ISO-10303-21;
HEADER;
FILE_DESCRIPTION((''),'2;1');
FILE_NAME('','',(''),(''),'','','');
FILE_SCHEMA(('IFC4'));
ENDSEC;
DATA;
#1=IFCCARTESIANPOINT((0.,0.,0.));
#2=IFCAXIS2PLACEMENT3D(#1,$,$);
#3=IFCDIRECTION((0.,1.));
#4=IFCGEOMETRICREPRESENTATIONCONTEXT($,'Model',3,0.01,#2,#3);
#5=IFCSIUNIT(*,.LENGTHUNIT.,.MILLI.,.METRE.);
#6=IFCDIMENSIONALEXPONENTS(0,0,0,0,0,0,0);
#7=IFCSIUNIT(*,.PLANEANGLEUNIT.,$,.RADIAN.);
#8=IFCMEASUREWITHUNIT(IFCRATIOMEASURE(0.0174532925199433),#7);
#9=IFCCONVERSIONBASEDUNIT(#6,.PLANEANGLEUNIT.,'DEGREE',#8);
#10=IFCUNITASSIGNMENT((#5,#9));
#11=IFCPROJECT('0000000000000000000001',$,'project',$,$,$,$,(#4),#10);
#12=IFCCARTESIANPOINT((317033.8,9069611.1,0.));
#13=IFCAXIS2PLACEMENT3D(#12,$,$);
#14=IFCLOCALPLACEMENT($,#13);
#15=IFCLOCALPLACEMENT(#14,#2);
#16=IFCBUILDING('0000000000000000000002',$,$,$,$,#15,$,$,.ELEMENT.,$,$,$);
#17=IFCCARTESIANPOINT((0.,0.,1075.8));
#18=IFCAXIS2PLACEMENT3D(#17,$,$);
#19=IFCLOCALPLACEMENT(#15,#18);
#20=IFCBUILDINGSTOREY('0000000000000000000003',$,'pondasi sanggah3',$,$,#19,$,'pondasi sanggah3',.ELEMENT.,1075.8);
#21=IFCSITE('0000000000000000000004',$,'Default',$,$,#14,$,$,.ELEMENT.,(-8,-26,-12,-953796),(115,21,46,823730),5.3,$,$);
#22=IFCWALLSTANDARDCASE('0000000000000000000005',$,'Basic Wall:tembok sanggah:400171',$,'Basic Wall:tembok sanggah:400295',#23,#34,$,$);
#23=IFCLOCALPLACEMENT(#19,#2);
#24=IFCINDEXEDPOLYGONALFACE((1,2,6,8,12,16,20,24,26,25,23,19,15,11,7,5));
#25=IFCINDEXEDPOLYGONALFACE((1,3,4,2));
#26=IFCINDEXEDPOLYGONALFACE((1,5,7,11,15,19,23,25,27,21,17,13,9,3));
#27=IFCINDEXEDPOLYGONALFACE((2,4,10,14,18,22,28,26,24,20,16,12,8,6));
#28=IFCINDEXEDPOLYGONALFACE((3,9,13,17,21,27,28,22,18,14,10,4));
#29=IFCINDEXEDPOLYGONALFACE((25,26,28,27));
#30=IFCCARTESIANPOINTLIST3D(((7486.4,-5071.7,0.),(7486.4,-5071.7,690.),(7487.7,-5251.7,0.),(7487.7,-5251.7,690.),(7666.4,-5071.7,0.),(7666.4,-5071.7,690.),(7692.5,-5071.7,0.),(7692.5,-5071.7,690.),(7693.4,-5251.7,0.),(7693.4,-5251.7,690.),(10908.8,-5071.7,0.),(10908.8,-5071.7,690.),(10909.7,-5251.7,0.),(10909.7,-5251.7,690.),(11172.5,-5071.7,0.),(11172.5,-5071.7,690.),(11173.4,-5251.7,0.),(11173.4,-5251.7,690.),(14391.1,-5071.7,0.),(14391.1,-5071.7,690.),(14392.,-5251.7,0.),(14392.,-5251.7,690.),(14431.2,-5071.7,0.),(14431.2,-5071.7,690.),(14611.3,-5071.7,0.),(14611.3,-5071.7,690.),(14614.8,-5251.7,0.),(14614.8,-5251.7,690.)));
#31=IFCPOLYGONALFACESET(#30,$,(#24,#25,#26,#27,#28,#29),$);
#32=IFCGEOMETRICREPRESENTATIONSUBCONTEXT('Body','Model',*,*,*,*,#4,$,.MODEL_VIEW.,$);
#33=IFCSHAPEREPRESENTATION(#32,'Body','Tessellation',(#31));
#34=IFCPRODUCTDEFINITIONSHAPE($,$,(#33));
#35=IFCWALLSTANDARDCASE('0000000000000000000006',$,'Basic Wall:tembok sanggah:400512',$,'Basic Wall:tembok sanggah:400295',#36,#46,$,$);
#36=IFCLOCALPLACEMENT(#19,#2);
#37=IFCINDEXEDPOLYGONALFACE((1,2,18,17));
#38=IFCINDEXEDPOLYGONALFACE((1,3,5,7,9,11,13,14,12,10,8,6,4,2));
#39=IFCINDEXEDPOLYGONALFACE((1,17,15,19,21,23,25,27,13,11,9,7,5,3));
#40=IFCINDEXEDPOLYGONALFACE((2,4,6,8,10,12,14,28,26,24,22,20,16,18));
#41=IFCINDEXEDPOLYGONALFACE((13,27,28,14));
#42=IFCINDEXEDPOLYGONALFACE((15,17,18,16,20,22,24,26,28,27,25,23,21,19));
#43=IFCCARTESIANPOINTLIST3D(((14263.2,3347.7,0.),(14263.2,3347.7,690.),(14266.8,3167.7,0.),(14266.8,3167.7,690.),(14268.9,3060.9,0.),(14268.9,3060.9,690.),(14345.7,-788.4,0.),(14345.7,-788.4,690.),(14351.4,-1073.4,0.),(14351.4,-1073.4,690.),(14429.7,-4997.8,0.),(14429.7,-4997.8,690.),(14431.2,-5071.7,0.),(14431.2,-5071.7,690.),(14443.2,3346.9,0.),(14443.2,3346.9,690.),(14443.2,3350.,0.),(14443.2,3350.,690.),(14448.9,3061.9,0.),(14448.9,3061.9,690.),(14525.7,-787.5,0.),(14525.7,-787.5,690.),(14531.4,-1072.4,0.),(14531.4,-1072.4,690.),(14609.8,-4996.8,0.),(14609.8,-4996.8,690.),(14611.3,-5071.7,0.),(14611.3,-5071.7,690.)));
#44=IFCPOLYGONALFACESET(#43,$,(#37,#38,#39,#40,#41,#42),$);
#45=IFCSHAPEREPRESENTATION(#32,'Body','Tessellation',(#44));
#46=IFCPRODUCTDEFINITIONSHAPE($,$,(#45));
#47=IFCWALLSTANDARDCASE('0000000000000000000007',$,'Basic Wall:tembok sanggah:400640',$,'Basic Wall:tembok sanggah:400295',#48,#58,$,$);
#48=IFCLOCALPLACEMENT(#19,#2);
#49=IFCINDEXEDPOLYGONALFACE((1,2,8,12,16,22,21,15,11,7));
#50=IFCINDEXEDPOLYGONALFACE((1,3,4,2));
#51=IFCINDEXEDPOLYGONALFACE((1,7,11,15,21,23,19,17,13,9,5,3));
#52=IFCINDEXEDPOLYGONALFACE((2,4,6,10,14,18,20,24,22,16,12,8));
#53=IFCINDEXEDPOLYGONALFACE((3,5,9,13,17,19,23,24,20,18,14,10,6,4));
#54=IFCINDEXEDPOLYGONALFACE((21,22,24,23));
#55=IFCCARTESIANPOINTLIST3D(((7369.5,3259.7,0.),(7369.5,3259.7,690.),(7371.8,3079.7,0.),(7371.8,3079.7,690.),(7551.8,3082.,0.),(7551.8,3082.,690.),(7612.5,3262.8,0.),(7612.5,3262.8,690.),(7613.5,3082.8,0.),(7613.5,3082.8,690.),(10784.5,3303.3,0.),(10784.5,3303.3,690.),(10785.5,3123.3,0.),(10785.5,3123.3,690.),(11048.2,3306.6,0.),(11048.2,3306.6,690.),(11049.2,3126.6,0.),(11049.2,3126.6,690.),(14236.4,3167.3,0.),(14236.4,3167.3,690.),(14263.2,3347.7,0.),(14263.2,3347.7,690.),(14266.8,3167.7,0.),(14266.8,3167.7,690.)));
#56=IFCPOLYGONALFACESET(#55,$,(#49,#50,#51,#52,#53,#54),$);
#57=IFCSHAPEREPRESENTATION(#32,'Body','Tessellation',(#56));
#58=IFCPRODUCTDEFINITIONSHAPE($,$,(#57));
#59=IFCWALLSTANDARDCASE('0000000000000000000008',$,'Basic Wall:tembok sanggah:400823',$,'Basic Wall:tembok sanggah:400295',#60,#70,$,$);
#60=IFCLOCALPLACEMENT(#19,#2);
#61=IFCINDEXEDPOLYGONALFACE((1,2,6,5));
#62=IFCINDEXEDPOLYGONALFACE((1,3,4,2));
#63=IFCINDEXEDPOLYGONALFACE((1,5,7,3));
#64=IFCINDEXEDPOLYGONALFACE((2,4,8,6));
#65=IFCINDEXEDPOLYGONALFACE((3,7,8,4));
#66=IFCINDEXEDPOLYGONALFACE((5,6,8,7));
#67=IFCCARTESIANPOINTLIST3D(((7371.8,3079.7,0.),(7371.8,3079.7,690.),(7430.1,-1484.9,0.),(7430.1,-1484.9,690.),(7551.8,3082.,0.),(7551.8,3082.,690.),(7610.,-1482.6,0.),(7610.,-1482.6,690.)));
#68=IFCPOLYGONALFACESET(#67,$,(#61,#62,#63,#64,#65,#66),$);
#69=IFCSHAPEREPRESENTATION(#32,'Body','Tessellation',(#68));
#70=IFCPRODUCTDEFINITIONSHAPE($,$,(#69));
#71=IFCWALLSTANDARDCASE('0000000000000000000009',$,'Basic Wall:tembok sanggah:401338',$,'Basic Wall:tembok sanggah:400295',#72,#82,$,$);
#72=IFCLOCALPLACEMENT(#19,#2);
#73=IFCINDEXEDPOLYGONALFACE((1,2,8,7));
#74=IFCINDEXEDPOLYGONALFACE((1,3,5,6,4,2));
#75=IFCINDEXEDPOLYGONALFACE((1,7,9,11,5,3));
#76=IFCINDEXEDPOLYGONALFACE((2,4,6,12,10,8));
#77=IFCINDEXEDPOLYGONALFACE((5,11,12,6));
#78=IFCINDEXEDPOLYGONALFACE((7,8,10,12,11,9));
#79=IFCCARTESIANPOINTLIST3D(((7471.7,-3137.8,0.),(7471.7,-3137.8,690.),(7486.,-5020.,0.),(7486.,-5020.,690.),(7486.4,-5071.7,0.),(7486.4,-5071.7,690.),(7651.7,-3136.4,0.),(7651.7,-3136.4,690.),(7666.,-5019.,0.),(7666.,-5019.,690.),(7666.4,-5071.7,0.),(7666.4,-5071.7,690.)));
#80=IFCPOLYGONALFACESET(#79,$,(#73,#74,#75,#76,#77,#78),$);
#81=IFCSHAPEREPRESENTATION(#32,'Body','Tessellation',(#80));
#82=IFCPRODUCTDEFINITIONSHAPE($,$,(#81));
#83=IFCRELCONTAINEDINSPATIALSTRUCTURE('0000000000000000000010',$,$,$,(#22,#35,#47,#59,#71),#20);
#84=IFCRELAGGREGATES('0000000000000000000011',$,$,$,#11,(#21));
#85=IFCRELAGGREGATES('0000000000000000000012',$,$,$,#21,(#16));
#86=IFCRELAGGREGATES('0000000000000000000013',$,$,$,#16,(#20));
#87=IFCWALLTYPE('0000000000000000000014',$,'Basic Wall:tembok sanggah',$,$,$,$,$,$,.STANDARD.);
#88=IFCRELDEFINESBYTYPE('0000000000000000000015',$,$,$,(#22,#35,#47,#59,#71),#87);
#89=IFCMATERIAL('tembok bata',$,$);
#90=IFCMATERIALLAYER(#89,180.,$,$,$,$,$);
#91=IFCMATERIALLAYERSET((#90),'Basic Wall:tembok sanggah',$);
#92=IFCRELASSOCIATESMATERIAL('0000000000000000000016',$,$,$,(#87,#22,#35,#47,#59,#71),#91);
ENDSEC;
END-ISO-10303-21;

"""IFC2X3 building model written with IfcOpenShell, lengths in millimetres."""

from ifc_helpers import new_model, entity, si_unit, converted_unit, direction, frame, frame_2d, origin, place, context, subcontext, project, spatial, polyline, rectangle, outline, extrude, material, layer, layer_set, layer_usage, type_object, element, save


model = new_model("IFC2X3")

# Units and contexts
model_context = context("Model", 3, precision=0.01, world=origin(), true_north=direction((0.0, 1.0)))
body_context = subcontext(model_context, "Body", "Model", "MODEL_VIEW")
ifc_project = project(units=[si_unit("LENGTHUNIT", "METRE", prefix="MILLI"), converted_unit("PLANEANGLEUNIT", "DEGREE", entity("IfcRatioMeasure", 0.0174532925199433), si_unit("PLANEANGLEUNIT", "RADIAN"), dimensions=[0, 0, 0, 0, 0, 0, 0])], contexts=[model_context])

# Site, building, storey
site_placement = place(None, frame((317033.8, 9069611.1, 0.0)))
site = spatial("IfcSite", under=ifc_project, at=site_placement, Name="Default", CompositionType="ELEMENT", RefLatitude=(-8, -26, -12, -953796), RefLongitude=(115, 21, 46, 823730), RefElevation=5.3)
building_placement = place(site_placement, origin())
building = spatial("IfcBuilding", under=site, at=building_placement, CompositionType="ELEMENT")
storey_placement = place(building_placement, frame((0.0, 0.0, 1075.8)))
storey = spatial("IfcBuildingStorey", under=building, at=storey_placement, Name="pondasi sanggah3", LongName="pondasi sanggah3", CompositionType="ELEMENT", Elevation=1075.8)

# Walls
ifc_material_1 = material(Name="tembok bata")
ifc_layer_1 = layer(ifc_material_1, 180.0)
ifc_layer_set_1 = layer_set([ifc_layer_1], Name="Basic Wall:tembok sanggah")
ifc_layer_usage_1 = layer_usage(ifc_layer_set_1, "AXIS2", "NEGATIVE", 90.0)
wall_type = type_object("IfcWallType", Name="Basic Wall:tembok sanggah", PredefinedType="STANDARD", material=ifc_layer_set_1)
wall_1_placement = place(storey_placement, frame((7486.4, -5161.7, 0.0)))
element("IfcWallStandardCase", 1, at=wall_1_placement, inside=storey, type_object=wall_type, material=ifc_layer_usage_1, Name="Basic Wall:tembok sanggah:400171", ObjectType="Basic Wall:tembok sanggah:400295", context=body_context, shape_type="SweptSolid", body=[
    extrude(outline(polyline([(7128.5, -90.0), (7124.9, 90.0), (6944.9, 90.0), (6904.7, 90.0), (3686.1, 90.0), (3422.4, 90.0), (206.1, 90.0), (180.0, 90.0), (0.0, 90.0), (1.4, -90.0), (207.1, -90.0), (3423.4, -90.0), (3687.1, -90.0), (6905.7, -90.0), (7128.5, -90.0)])), origin(), (0.0, 0.0, 1.0), 690.0),
])
ifc_layer_usage_2 = layer_usage(ifc_layer_set_1, "AXIS2", "NEGATIVE", 90.0)
wall_2_placement = place(storey_placement, frame((14521.3, -5073.5, 0.0), z_axis=(0.0, 0.0, 1.0), x_axis=(-0.019956, 0.999801, 0.0)))
element("IfcWallStandardCase", 2, at=wall_2_placement, inside=storey, type_object=wall_type, material=ifc_layer_usage_2, Name="Basic Wall:tembok sanggah:400512", ObjectType="Basic Wall:tembok sanggah:400295", context=body_context, shape_type="SweptSolid", body=[
    extrude(outline(polyline([(8423.4, -90.0), (8424.7, 90.0), (8244.6, 90.0), (8137.9, 90.0), (4287.7, 90.0), (4002.7, 90.0), (77.6, 90.0), (3.6, 90.0), (0.0, -90.0), (74.9, -90.0), (4000.1, -90.0), (4285.1, -90.0), (8135.2, -90.0), (8420.3, -90.0), (8423.4, -90.0)])), origin(), (0.0, 0.0, 1.0), 690.0),
])
ifc_layer_usage_3 = layer_usage(ifc_layer_set_1, "AXIS2", "NEGATIVE", 90.0)
wall_3_placement = place(storey_placement, frame((14265.6, 3257.7, 0.0), z_axis=(0.0, 0.0, 1.0), x_axis=(-0.999919, -0.012763, 0.0)))
element("IfcWallStandardCase", 3, at=wall_3_placement, inside=storey, type_object=wall_type, material=ifc_layer_usage_3, Name="Basic Wall:tembok sanggah:400640", ObjectType="Basic Wall:tembok sanggah:400295", context=body_context, shape_type="SweptSolid", body=[
    extrude(outline(polyline([(6895.5, -90.0), (6895.5, 90.0), (6715.5, 90.0), (6653.8, 90.0), (3481.5, 90.0), (3217.8, 90.0), (30.3, 90.0), (0.0, 90.0), (1.3, -90.0), (3216.5, -90.0), (3480.2, -90.0), (6652.5, -90.0), (6895.5, -90.0)])), origin(), (0.0, 0.0, 1.0), 690.0),
])
ifc_layer_usage_4 = layer_usage(ifc_layer_set_1, "AXIS2", "NEGATIVE", 90.0)
wall_4_placement = place(storey_placement, frame((7461.8, 3080.8, 0.0), z_axis=(0.0, 0.0, 1.0), x_axis=(0.012763, -0.999919, 0.0)))
element("IfcWallStandardCase", 4, at=wall_4_placement, inside=storey, type_object=wall_type, material=ifc_layer_usage_4, Name="Basic Wall:tembok sanggah:400823", ObjectType="Basic Wall:tembok sanggah:400295", context=body_context, shape_type="SweptSolid", body=[
    extrude(rectangle(XDim=4565.0, YDim=180.0, at=frame_2d((2282.5, 0.0), x_axis=(-1.0, 0.0))), origin(), (0.0, 0.0, 1.0), 690.0),
])
ifc_layer_usage_5 = layer_usage(ifc_layer_set_1, "AXIS2", "NEGATIVE", 90.0)
wall_5_placement = place(storey_placement, frame((7576.4, -5072.4, 0.0), z_axis=(0.0, 0.0, 1.0), x_axis=(-0.007572, 0.999971, 0.0)))
element("IfcWallStandardCase", 5, at=wall_5_placement, inside=storey, type_object=wall_type, material=ifc_layer_usage_5, Name="Basic Wall:tembok sanggah:401338", ObjectType="Basic Wall:tembok sanggah:400295", context=body_context, shape_type="SweptSolid", body=[
    extrude(outline(polyline([(1935.4, -90.0), (1935.4, 90.0), (53.1, 90.0), (1.4, 90.0), (0.0, -90.0), (52.7, -90.0), (1935.4, -90.0)])), origin(), (0.0, 0.0, 1.0), 690.0),
])

save(model, "model.ifc")
